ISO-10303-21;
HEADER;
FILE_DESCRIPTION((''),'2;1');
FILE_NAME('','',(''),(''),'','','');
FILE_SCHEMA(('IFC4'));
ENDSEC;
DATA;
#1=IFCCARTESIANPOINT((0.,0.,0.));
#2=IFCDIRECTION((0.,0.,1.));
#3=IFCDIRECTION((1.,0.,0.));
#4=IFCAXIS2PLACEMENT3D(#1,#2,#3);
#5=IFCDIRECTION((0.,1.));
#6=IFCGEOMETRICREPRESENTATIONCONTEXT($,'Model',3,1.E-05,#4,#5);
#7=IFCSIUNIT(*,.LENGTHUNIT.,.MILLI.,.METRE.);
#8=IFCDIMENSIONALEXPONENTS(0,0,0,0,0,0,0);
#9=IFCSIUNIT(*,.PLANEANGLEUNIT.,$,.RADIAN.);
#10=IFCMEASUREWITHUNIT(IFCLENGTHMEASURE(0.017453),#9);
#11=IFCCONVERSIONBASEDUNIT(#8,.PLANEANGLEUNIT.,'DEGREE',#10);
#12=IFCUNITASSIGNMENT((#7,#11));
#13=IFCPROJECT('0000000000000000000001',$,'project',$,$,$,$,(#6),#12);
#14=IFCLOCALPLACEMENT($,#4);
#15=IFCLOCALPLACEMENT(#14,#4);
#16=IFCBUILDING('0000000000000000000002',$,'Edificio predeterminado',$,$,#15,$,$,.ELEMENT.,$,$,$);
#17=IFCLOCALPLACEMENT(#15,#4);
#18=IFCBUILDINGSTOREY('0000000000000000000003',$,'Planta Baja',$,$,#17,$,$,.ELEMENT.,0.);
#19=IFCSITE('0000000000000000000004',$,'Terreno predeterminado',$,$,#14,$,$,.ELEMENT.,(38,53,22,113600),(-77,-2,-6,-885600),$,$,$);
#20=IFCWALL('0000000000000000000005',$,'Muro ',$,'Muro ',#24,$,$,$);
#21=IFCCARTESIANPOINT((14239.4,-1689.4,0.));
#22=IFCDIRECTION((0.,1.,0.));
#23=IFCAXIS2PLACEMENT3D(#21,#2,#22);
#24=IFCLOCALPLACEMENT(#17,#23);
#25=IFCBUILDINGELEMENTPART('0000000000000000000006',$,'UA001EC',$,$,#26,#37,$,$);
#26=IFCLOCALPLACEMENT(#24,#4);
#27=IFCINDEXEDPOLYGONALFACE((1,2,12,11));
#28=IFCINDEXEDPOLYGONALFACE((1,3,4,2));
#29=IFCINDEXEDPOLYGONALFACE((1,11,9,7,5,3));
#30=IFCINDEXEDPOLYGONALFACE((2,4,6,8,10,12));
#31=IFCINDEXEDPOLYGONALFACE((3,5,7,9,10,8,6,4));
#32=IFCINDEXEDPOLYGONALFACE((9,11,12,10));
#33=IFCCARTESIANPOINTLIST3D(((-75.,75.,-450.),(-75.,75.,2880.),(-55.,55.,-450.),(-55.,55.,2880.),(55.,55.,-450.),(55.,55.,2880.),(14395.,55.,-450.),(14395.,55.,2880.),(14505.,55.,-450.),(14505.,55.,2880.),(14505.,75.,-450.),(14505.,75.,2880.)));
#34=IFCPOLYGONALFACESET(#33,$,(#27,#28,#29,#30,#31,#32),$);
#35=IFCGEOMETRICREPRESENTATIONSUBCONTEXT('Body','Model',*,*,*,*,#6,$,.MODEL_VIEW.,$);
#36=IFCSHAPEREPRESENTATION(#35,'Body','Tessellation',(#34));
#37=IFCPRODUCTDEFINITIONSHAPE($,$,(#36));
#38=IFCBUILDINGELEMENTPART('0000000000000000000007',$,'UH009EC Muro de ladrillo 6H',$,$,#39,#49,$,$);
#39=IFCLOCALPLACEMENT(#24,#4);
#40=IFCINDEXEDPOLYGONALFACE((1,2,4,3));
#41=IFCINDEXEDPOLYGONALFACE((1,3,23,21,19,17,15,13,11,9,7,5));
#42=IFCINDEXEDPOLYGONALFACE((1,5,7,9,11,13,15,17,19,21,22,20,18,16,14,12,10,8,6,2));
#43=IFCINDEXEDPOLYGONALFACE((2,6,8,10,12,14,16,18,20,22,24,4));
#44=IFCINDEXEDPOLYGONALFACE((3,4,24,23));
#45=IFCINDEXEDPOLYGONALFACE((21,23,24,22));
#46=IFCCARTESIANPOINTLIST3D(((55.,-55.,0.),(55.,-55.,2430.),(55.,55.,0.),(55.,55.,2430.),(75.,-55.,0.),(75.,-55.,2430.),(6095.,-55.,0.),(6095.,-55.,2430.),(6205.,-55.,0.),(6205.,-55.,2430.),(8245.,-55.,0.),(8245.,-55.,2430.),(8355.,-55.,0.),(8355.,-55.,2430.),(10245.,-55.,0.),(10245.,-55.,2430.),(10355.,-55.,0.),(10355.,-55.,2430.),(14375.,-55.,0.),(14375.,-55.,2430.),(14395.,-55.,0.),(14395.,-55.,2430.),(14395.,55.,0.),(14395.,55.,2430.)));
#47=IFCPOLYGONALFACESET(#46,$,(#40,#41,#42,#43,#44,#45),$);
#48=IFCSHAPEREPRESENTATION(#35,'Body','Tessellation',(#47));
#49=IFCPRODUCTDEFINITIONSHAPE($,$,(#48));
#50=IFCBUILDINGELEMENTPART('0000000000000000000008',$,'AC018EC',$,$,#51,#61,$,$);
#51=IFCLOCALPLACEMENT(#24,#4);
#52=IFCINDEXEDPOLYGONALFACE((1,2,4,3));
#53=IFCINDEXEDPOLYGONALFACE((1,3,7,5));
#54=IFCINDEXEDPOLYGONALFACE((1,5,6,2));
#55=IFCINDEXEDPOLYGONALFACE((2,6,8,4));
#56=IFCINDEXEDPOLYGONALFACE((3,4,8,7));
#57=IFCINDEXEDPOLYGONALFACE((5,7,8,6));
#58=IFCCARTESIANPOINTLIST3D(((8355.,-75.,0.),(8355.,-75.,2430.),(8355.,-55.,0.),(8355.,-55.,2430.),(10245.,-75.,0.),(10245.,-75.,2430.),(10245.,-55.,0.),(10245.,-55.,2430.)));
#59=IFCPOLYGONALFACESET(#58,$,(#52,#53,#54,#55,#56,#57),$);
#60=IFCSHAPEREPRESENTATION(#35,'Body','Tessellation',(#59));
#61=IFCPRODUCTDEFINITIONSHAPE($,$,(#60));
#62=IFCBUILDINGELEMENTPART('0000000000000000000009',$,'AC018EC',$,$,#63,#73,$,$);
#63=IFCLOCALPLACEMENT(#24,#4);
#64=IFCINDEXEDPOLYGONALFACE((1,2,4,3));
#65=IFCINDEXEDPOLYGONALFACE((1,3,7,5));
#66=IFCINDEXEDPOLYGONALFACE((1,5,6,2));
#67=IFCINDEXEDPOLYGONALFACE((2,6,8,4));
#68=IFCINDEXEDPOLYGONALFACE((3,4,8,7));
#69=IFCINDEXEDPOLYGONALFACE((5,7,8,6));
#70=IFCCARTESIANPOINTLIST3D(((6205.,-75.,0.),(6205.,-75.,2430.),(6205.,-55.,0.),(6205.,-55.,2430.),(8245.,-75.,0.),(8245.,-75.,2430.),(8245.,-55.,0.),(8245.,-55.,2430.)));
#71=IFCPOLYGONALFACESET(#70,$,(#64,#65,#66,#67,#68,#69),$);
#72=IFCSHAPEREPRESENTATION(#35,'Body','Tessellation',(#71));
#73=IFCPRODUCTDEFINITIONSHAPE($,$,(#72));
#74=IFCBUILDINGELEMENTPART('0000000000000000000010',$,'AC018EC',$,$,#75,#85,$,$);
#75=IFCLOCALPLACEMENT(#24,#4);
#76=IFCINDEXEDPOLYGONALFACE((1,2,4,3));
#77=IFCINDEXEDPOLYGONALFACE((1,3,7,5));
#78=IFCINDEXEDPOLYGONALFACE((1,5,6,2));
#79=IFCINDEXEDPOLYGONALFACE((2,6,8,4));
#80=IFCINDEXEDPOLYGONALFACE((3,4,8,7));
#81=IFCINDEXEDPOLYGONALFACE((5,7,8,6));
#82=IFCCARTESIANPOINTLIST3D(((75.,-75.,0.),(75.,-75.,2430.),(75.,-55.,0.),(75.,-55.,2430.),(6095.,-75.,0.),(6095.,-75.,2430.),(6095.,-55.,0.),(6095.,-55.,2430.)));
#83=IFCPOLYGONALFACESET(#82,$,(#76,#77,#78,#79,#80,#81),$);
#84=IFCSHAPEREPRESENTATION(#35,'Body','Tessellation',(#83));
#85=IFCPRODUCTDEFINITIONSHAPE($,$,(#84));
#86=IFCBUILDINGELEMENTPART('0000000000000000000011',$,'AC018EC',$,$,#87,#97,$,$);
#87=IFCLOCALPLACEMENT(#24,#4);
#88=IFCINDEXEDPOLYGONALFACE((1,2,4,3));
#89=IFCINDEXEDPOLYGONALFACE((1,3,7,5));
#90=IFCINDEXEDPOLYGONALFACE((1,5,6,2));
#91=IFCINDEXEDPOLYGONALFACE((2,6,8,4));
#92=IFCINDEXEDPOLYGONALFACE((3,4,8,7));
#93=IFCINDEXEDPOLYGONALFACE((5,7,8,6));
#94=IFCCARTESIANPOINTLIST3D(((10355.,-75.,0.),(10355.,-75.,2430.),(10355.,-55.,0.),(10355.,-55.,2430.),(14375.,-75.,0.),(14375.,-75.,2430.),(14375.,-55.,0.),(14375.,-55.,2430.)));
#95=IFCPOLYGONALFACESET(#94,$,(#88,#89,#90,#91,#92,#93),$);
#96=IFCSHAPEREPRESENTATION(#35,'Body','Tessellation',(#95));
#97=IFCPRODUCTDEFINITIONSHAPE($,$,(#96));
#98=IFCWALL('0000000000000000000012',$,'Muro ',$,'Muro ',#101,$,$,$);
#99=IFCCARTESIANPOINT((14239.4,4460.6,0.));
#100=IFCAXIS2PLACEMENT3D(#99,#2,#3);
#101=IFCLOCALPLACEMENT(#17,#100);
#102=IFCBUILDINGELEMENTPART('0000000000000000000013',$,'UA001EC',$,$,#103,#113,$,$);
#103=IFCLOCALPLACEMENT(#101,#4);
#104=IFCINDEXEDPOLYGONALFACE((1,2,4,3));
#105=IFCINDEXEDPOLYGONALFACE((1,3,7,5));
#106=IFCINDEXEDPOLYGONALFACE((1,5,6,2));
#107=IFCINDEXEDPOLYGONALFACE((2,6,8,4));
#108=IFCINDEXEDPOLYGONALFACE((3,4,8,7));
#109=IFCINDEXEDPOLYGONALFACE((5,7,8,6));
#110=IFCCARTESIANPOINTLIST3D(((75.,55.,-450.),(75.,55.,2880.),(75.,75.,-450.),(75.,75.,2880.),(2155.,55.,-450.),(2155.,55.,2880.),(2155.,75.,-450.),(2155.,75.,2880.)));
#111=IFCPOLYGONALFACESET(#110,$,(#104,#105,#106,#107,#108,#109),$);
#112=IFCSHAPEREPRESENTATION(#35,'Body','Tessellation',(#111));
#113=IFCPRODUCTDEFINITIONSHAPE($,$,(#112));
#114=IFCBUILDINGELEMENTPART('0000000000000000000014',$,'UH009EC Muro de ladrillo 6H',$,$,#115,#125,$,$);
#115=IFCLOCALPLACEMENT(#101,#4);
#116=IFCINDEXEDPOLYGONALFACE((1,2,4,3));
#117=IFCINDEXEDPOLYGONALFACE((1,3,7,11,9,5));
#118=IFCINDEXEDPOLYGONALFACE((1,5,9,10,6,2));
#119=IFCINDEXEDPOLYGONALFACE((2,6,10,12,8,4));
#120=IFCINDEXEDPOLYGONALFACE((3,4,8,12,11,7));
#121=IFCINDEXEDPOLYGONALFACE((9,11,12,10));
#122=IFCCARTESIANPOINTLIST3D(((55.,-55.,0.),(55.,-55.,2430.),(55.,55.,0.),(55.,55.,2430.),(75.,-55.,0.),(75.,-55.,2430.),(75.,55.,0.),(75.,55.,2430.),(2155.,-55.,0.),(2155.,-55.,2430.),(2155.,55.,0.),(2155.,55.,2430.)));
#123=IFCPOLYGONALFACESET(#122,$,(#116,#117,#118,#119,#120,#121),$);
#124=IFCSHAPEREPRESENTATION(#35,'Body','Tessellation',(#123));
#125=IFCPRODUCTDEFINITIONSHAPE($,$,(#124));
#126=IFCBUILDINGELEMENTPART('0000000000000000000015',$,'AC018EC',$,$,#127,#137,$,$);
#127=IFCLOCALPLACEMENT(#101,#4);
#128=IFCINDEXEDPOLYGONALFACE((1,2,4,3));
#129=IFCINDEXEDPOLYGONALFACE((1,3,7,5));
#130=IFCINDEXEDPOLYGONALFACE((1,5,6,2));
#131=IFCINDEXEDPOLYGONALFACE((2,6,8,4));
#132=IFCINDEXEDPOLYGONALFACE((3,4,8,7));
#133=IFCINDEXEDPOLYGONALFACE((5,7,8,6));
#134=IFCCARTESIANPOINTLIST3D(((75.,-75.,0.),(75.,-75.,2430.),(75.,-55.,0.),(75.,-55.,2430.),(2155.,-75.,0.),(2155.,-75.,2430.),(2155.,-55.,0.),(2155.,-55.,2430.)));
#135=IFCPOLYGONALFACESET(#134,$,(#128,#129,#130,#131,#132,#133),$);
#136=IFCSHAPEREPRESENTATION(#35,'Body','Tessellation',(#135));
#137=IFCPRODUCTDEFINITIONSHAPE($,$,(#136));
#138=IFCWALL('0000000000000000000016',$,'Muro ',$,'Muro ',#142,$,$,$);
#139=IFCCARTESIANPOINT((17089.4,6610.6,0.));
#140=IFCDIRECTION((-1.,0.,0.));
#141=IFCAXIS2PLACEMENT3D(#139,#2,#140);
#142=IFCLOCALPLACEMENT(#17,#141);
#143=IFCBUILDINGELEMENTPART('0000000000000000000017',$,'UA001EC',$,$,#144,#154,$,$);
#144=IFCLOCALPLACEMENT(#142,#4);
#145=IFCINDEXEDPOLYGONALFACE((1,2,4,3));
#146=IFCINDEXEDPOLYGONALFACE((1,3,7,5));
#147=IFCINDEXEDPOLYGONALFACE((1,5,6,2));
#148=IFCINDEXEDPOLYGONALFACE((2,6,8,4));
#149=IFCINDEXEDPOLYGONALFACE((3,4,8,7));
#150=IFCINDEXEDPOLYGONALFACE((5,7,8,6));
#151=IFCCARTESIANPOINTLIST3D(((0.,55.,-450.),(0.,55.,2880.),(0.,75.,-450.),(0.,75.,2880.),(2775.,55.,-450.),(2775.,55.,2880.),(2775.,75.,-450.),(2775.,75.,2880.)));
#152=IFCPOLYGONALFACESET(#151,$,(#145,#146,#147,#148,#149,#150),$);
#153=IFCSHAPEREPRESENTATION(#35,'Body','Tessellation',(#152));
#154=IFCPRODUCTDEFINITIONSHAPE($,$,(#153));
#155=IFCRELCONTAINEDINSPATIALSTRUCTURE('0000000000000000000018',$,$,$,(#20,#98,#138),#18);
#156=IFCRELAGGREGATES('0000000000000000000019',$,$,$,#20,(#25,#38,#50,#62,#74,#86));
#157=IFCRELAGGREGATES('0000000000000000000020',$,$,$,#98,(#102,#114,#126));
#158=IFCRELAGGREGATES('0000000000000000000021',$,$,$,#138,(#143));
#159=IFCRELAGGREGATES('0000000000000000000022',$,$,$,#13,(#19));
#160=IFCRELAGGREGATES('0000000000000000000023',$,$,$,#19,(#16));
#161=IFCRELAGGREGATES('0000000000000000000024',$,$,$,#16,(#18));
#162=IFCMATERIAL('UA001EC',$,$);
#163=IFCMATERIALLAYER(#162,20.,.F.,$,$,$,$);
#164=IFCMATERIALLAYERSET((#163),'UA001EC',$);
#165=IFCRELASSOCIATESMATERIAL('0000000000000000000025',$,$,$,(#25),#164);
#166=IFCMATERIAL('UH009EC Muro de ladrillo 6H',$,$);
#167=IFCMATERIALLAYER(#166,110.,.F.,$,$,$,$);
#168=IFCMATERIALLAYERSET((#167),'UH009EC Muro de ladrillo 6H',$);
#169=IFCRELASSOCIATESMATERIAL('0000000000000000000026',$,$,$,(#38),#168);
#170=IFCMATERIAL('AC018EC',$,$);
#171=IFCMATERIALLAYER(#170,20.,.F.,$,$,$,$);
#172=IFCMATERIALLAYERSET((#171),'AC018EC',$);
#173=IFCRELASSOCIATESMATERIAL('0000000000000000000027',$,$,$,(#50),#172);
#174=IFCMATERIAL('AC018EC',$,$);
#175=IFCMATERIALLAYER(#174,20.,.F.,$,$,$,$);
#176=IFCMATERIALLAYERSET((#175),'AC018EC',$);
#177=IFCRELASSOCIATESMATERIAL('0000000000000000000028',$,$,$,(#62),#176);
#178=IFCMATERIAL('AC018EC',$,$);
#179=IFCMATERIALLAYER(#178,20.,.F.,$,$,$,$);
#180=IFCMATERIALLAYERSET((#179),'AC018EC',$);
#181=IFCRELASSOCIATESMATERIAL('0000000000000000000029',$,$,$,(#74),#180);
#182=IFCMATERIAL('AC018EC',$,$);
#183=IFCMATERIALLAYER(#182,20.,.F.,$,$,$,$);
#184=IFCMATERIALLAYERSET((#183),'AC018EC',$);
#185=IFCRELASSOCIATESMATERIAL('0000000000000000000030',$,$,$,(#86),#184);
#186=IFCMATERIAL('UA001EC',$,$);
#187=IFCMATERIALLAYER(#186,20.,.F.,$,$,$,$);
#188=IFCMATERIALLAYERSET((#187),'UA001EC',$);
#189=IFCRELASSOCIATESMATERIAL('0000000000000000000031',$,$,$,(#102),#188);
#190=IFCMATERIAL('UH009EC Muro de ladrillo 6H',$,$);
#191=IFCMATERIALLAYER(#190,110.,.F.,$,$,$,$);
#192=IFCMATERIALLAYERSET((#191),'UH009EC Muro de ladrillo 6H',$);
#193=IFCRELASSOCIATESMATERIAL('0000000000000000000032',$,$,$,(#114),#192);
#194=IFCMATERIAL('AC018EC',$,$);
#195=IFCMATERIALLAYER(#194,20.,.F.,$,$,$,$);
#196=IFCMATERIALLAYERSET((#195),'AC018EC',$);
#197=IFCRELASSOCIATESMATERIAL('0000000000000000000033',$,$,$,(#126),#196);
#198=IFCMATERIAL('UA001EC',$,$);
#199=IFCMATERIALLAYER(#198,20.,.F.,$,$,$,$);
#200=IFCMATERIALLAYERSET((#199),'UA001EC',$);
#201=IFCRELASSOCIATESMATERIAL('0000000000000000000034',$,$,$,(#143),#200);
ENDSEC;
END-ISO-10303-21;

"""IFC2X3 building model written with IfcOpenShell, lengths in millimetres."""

from ifc_helpers import new_model, entity, si_unit, converted_unit, direction, frame, origin_with_axes, place, context, subcontext, project, spatial, polyline, outline, extrude, material, layer, layer_set, layer_usage, element, aggregate, save


model = new_model("IFC2X3")

# Units and contexts
model_context = context("Model", 3, precision=1e-05, world=origin_with_axes(), true_north=direction((0.0, 1.0)))
body_context = subcontext(model_context, "Body", "Model", "MODEL_VIEW")
ifc_project = project(units=[si_unit("LENGTHUNIT", "METRE", prefix="MILLI"), converted_unit("PLANEANGLEUNIT", "DEGREE", entity("IfcLengthMeasure", 0.017453), si_unit("PLANEANGLEUNIT", "RADIAN"), dimensions=[0, 0, 0, 0, 0, 0, 0])], contexts=[model_context])

# Site, building, storey
site_placement = place(None, origin_with_axes())
site = spatial("IfcSite", under=ifc_project, at=site_placement, Name="Terreno predeterminado", CompositionType="ELEMENT", RefLatitude=(38, 53, 22, 113600), RefLongitude=(-77, -2, -6, -885600))
building_placement = place(site_placement, origin_with_axes())
building = spatial("IfcBuilding", under=site, at=building_placement, Name="Edificio predeterminado", CompositionType="ELEMENT")
storey_placement = place(building_placement, origin_with_axes())
storey = spatial("IfcBuildingStorey", under=building, at=storey_placement, Name="Planta Baja", CompositionType="ELEMENT", Elevation=0.0)

# Walls, building element parts
wall_1_placement = place(storey_placement, frame((14239.4, -1689.4, 0.0), z_axis=(0.0, 0.0, 1.0), x_axis=(0.0, 1.0, 0.0)))
wall_1 = element("IfcWall", 1, at=wall_1_placement, inside=storey, Name="Muro ", ObjectType="Muro ")
ifc_material_1 = material(Name="UA001EC")
ifc_layer_1 = layer(ifc_material_1, 20.0, ventilated=False)
ifc_layer_set_1 = layer_set([ifc_layer_1], Name="UA001EC")
ifc_layer_usage_1 = layer_usage(ifc_layer_set_1, "AXIS2", "NEGATIVE", -75.0)
building_element_part_1_placement = place(wall_1_placement, origin_with_axes())
building_element_part_1 = element("IfcBuildingElementPart", 2, at=building_element_part_1_placement, material=ifc_layer_usage_1, Name="UA001EC", context=body_context, shape_type="SweptSolid", body=[
    extrude(outline(polyline([(14505.0, 75.0), (14505.0, 55.0), (14395.0, 55.0), (55.0, 55.0), (-55.0, 55.0), (-75.0, 75.0), (14505.0, 75.0)])), frame((0.0, 0.0, -450.0), z_axis=(0.0, 0.0, 1.0), x_axis=(1.0, 0.0, 0.0)), (0.0, 0.0, 1.0), 3330.0),
])
ifc_material_2 = material(Name="UH009EC Muro de ladrillo 6H")
ifc_layer_2 = layer(ifc_material_2, 110.0, ventilated=False)
ifc_layer_set_2 = layer_set([ifc_layer_2], Name="UH009EC Muro de ladrillo 6H")
ifc_layer_usage_2 = layer_usage(ifc_layer_set_2, "AXIS2", "NEGATIVE", -55.0)
building_element_part_2_placement = place(wall_1_placement, origin_with_axes())
building_element_part_2 = element("IfcBuildingElementPart", 3, at=building_element_part_2_placement, material=ifc_layer_usage_2, Name="UH009EC Muro de ladrillo 6H", context=body_context, shape_type="SweptSolid", body=[
    extrude(outline(polyline([(14395.0, 55.0), (14395.0, -55.0), (14375.0, -55.0), (10355.0, -55.0), (10245.0, -55.0), (8355.0, -55.0), (8245.0, -55.0), (6205.0, -55.0), (6095.0, -55.0), (75.0, -55.0), (55.0, -55.0), (55.0, 55.0), (14395.0, 55.0)])), origin_with_axes(), (0.0, 0.0, 1.0), 2430.0),
])
ifc_material_3 = material(Name="AC018EC")
ifc_layer_3 = layer(ifc_material_3, 20.0, ventilated=False)
ifc_layer_set_3 = layer_set([ifc_layer_3], Name="AC018EC")
ifc_layer_usage_3 = layer_usage(ifc_layer_set_3, "AXIS2", "NEGATIVE", 55.0)
building_element_part_3_placement = place(wall_1_placement, origin_with_axes())
building_element_part_3 = element("IfcBuildingElementPart", 4, at=building_element_part_3_placement, material=ifc_layer_usage_3, Name="AC018EC", context=body_context, shape_type="SweptSolid", body=[
    extrude(outline(polyline([(8355.0, -55.0), (10245.0, -55.0), (10245.0, -75.0), (8355.0, -75.0), (8355.0, -55.0)])), origin_with_axes(), (0.0, 0.0, 1.0), 2430.0),
])
ifc_material_4 = material(Name="AC018EC")
ifc_layer_4 = layer(ifc_material_4, 20.0, ventilated=False)
ifc_layer_set_4 = layer_set([ifc_layer_4], Name="AC018EC")
ifc_layer_usage_4 = layer_usage(ifc_layer_set_4, "AXIS2", "NEGATIVE", 55.0)
building_element_part_4_placement = place(wall_1_placement, origin_with_axes())
building_element_part_4 = element("IfcBuildingElementPart", 5, at=building_element_part_4_placement, material=ifc_layer_usage_4, Name="AC018EC", context=body_context, shape_type="SweptSolid", body=[
    extrude(outline(polyline([(8245.0, -55.0), (8245.0, -75.0), (6205.0, -75.0), (6205.0, -55.0), (8245.0, -55.0)])), origin_with_axes(), (0.0, 0.0, 1.0), 2430.0),
])
ifc_material_5 = material(Name="AC018EC")
ifc_layer_5 = layer(ifc_material_5, 20.0, ventilated=False)
ifc_layer_set_5 = layer_set([ifc_layer_5], Name="AC018EC")
ifc_layer_usage_5 = layer_usage(ifc_layer_set_5, "AXIS2", "NEGATIVE", 55.0)
building_element_part_5_placement = place(wall_1_placement, origin_with_axes())
building_element_part_5 = element("IfcBuildingElementPart", 6, at=building_element_part_5_placement, material=ifc_layer_usage_5, Name="AC018EC", context=body_context, shape_type="SweptSolid", body=[
    extrude(outline(polyline([(6095.0, -55.0), (6095.0, -75.0), (75.0, -75.0), (75.0, -55.0), (6095.0, -55.0)])), origin_with_axes(), (0.0, 0.0, 1.0), 2430.0),
])
ifc_material_6 = material(Name="AC018EC")
ifc_layer_6 = layer(ifc_material_6, 20.0, ventilated=False)
ifc_layer_set_6 = layer_set([ifc_layer_6], Name="AC018EC")
ifc_layer_usage_6 = layer_usage(ifc_layer_set_6, "AXIS2", "NEGATIVE", 55.0)
building_element_part_6_placement = place(wall_1_placement, origin_with_axes())
building_element_part_6 = element("IfcBuildingElementPart", 7, at=building_element_part_6_placement, material=ifc_layer_usage_6, Name="AC018EC", context=body_context, shape_type="SweptSolid", body=[
    extrude(outline(polyline([(14375.0, -55.0), (14375.0, -75.0), (10355.0, -75.0), (10355.0, -55.0), (14375.0, -55.0)])), origin_with_axes(), (0.0, 0.0, 1.0), 2430.0),
])
aggregate(wall_1, [building_element_part_1, building_element_part_2, building_element_part_3, building_element_part_4, building_element_part_5, building_element_part_6])
wall_2_placement = place(storey_placement, frame((14239.4, 4460.6, 0.0), z_axis=(0.0, 0.0, 1.0), x_axis=(1.0, 0.0, 0.0)))
wall_2 = element("IfcWall", 8, at=wall_2_placement, inside=storey, Name="Muro ", ObjectType="Muro ")
ifc_material_7 = material(Name="UA001EC")
ifc_layer_7 = layer(ifc_material_7, 20.0, ventilated=False)
ifc_layer_set_7 = layer_set([ifc_layer_7], Name="UA001EC")
ifc_layer_usage_7 = layer_usage(ifc_layer_set_7, "AXIS2", "NEGATIVE", -75.0)
building_element_part_7_placement = place(wall_2_placement, origin_with_axes())
building_element_part_7 = element("IfcBuildingElementPart", 9, at=building_element_part_7_placement, material=ifc_layer_usage_7, Name="UA001EC", context=body_context, shape_type="SweptSolid", body=[
    extrude(outline(polyline([(2155.0, 75.0), (2155.0, 55.0), (75.0, 55.0), (75.0, 75.0), (2155.0, 75.0)])), frame((0.0, 0.0, -450.0), z_axis=(0.0, 0.0, 1.0), x_axis=(1.0, 0.0, 0.0)), (0.0, 0.0, 1.0), 3330.0),
])
ifc_material_8 = material(Name="UH009EC Muro de ladrillo 6H")
ifc_layer_8 = layer(ifc_material_8, 110.0, ventilated=False)
ifc_layer_set_8 = layer_set([ifc_layer_8], Name="UH009EC Muro de ladrillo 6H")
ifc_layer_usage_8 = layer_usage(ifc_layer_set_8, "AXIS2", "NEGATIVE", -55.0)
building_element_part_8_placement = place(wall_2_placement, origin_with_axes())
building_element_part_8 = element("IfcBuildingElementPart", 10, at=building_element_part_8_placement, material=ifc_layer_usage_8, Name="UH009EC Muro de ladrillo 6H", context=body_context, shape_type="SweptSolid", body=[
    extrude(outline(polyline([(2155.0, 55.0), (2155.0, -55.0), (75.0, -55.0), (55.0, -55.0), (55.0, 55.0), (75.0, 55.0), (2155.0, 55.0)])), origin_with_axes(), (0.0, 0.0, 1.0), 2430.0),
])
ifc_material_9 = material(Name="AC018EC")
ifc_layer_9 = layer(ifc_material_9, 20.0, ventilated=False)
ifc_layer_set_9 = layer_set([ifc_layer_9], Name="AC018EC")
ifc_layer_usage_9 = layer_usage(ifc_layer_set_9, "AXIS2", "NEGATIVE", 55.0)
building_element_part_9_placement = place(wall_2_placement, origin_with_axes())
building_element_part_9 = element("IfcBuildingElementPart", 11, at=building_element_part_9_placement, material=ifc_layer_usage_9, Name="AC018EC", context=body_context, shape_type="SweptSolid", body=[
    extrude(outline(polyline([(2155.0, -55.0), (2155.0, -75.0), (75.0, -75.0), (75.0, -55.0), (2155.0, -55.0)])), origin_with_axes(), (0.0, 0.0, 1.0), 2430.0),
])
aggregate(wall_2, [building_element_part_7, building_element_part_8, building_element_part_9])

# Wall, building element part
wall_3_placement = place(storey_placement, frame((17089.4, 6610.6, 0.0), z_axis=(0.0, 0.0, 1.0), x_axis=(-1.0, 0.0, 0.0)))
wall_3 = element("IfcWall", 12, at=wall_3_placement, inside=storey, Name="Muro ", ObjectType="Muro ")
ifc_material_10 = material(Name="UA001EC")
ifc_layer_10 = layer(ifc_material_10, 20.0, ventilated=False)
ifc_layer_set_10 = layer_set([ifc_layer_10], Name="UA001EC")
ifc_layer_usage_10 = layer_usage(ifc_layer_set_10, "AXIS2", "NEGATIVE", -75.0)
building_element_part_10_placement = place(wall_3_placement, origin_with_axes())
building_element_part_10 = element("IfcBuildingElementPart", 13, at=building_element_part_10_placement, material=ifc_layer_usage_10, Name="UA001EC", context=body_context, shape_type="SweptSolid", body=[
    extrude(outline(polyline([(0.0, 75.0), (2775.0, 75.0), (2775.0, 55.0), (0.0, 55.0), (0.0, 75.0)])), frame((0.0, 0.0, -450.0), z_axis=(0.0, 0.0, 1.0), x_axis=(1.0, 0.0, 0.0)), (0.0, 0.0, 1.0), 3330.0),
])
aggregate(wall_3, [building_element_part_10])

save(model, "model.ifc")
